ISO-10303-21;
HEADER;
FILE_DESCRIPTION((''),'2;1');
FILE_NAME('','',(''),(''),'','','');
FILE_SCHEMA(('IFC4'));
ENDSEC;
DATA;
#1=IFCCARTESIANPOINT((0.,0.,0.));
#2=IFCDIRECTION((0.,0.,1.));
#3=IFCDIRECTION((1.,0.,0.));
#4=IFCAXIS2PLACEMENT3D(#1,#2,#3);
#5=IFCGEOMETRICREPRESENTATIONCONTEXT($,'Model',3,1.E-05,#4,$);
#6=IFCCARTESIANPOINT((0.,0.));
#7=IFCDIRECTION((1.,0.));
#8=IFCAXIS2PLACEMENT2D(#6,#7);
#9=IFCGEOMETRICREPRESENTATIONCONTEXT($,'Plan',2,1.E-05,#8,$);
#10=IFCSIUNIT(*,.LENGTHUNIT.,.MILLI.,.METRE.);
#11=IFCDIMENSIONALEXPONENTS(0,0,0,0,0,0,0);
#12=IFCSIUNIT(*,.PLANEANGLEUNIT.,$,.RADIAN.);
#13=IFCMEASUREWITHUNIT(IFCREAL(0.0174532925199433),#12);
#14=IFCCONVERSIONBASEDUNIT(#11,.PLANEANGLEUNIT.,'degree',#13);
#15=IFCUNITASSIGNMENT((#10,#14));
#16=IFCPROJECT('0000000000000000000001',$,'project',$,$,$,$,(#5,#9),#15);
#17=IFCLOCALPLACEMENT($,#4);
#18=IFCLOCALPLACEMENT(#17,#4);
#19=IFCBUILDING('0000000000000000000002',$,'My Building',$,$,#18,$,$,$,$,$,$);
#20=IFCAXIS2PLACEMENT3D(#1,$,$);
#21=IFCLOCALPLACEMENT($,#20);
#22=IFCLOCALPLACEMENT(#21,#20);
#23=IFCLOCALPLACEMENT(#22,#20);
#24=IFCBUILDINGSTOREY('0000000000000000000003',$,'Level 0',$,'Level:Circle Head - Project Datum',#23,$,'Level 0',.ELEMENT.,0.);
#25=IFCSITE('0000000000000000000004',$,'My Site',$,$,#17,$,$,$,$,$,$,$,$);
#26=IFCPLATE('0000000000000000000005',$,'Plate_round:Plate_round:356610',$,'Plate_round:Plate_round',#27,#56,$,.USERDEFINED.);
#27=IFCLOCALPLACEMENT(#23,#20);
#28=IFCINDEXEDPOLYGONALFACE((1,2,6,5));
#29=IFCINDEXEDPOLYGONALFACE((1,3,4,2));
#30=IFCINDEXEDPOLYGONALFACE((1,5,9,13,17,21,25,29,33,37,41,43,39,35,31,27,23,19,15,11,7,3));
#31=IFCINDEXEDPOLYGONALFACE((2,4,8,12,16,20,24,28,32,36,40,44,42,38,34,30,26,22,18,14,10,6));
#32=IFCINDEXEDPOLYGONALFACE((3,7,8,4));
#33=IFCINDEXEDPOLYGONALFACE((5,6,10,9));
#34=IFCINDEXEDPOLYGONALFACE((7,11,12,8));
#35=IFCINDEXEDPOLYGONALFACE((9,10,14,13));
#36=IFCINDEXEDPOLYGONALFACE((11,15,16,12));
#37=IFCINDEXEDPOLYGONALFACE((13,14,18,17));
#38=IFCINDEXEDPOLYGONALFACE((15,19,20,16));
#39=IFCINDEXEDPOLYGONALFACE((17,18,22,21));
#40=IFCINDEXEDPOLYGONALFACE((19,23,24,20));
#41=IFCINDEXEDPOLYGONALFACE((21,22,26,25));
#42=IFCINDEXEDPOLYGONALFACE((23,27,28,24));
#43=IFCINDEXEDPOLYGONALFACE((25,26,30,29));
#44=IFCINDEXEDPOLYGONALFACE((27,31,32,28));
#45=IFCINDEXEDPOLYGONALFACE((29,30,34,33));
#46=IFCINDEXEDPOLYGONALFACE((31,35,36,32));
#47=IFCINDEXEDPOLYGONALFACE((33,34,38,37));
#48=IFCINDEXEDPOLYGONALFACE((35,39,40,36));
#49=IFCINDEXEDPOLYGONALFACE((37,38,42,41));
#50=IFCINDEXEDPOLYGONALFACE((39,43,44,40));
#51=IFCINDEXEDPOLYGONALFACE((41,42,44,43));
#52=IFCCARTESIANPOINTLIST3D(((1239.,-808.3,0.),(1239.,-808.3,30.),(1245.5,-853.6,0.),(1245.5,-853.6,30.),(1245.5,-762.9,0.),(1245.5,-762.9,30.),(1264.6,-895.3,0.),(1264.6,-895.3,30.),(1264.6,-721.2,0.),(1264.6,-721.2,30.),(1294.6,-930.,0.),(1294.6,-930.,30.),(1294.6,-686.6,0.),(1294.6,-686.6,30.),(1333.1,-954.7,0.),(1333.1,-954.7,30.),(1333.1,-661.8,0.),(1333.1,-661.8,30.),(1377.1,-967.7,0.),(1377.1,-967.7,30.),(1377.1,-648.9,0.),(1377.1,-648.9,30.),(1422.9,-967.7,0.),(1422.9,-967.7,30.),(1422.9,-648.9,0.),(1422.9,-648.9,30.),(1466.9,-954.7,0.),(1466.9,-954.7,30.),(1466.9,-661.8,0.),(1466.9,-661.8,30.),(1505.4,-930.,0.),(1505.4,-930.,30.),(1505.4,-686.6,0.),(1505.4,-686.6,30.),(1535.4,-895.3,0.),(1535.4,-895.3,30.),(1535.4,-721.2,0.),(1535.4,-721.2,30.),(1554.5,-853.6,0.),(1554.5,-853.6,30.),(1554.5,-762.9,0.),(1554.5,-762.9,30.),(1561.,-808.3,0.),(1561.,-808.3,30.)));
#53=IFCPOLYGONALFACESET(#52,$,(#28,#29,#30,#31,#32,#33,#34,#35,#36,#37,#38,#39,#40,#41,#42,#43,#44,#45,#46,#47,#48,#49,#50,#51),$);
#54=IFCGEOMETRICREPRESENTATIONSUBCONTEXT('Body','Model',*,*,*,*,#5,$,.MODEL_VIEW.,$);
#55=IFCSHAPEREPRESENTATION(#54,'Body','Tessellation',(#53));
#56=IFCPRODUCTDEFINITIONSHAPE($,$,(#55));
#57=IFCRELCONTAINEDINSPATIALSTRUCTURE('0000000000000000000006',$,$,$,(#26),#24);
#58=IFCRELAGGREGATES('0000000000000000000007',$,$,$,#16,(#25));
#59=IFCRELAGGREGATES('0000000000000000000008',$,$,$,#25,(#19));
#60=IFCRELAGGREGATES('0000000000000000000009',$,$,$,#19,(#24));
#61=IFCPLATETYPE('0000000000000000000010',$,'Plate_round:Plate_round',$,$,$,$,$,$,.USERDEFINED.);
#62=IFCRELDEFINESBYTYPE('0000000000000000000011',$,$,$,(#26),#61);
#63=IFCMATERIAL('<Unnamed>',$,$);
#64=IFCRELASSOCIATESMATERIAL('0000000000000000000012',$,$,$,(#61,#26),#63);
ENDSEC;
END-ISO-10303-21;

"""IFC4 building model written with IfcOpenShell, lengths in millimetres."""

from ifc_helpers import new_model, entity, si_unit, converted_unit, frame, origin, origin_with_axes, origin_2d_with_axis, place, context, subcontext, project, spatial, arc, indexed_curve, outline, extrude, source, transform, mapped, material, type_object, type_shapes, element, save


model = new_model("IFC4")

# Units and contexts
model_context = context("Model", 3, precision=1e-05, world=origin_with_axes())
plan_context = context("Plan", 2, precision=1e-05, world=origin_2d_with_axis())
body_context = subcontext(model_context, "Body", "Model", "MODEL_VIEW")
ifc_project = project(units=[si_unit("LENGTHUNIT", "METRE", prefix="MILLI"), converted_unit("PLANEANGLEUNIT", "degree", entity("IfcReal", 0.0174532925199433), si_unit("PLANEANGLEUNIT", "RADIAN"), dimensions=[0, 0, 0, 0, 0, 0, 0])], contexts=[model_context, plan_context])

# Site, building, storey
site_placement = place(None, origin_with_axes())
site = spatial("IfcSite", under=ifc_project, at=site_placement, Name="My Site")
building_placement = place(site_placement, origin_with_axes())
building = spatial("IfcBuilding", under=site, at=building_placement, Name="My Building")
placement_1 = place(None, origin())
placement_2 = place(placement_1, origin())
storey_placement = place(placement_2, origin())
storey = spatial("IfcBuildingStorey", under=building, at=storey_placement, Name="Level 0", ObjectType="Level:Circle Head - Project Datum", LongName="Level 0", CompositionType="ELEMENT", Elevation=0.0)

# Plate
ifc_material_1 = material(Name="<Unnamed>")
plate_type = type_object("IfcPlateType", Name="Plate_round:Plate_round", PredefinedType="USERDEFINED", material=ifc_material_1)
shared_shape = source(origin(), body_context, "Body", "SweptSolid", [
    extrude(outline(indexed_curve([(-161.0, 0.0), (0.0, -161.0), (161.0, 0.0), (0.0, 161.0)], segments=[arc(1, 2, 3), arc(3, 4, 1)], self_intersect=False)), origin(), (0.0, 0.0, 1.0), 30.0),
])
type_shapes(plate_type, [shared_shape])
plate_placement = place(storey_placement, frame((1400.0, -808.3, 0.0)))
element("IfcPlate", 1, at=plate_placement, inside=storey, type_object=plate_type, material=ifc_material_1, Name="Plate_round:Plate_round:356610", ObjectType="Plate_round:Plate_round", PredefinedType="USERDEFINED", context=body_context, shape_type="MappedRepresentation", body=[
    mapped(shared_shape, transform((0.0, 0.0, 0.0), scale=1.0)),
])

save(model, "model.ifc")
